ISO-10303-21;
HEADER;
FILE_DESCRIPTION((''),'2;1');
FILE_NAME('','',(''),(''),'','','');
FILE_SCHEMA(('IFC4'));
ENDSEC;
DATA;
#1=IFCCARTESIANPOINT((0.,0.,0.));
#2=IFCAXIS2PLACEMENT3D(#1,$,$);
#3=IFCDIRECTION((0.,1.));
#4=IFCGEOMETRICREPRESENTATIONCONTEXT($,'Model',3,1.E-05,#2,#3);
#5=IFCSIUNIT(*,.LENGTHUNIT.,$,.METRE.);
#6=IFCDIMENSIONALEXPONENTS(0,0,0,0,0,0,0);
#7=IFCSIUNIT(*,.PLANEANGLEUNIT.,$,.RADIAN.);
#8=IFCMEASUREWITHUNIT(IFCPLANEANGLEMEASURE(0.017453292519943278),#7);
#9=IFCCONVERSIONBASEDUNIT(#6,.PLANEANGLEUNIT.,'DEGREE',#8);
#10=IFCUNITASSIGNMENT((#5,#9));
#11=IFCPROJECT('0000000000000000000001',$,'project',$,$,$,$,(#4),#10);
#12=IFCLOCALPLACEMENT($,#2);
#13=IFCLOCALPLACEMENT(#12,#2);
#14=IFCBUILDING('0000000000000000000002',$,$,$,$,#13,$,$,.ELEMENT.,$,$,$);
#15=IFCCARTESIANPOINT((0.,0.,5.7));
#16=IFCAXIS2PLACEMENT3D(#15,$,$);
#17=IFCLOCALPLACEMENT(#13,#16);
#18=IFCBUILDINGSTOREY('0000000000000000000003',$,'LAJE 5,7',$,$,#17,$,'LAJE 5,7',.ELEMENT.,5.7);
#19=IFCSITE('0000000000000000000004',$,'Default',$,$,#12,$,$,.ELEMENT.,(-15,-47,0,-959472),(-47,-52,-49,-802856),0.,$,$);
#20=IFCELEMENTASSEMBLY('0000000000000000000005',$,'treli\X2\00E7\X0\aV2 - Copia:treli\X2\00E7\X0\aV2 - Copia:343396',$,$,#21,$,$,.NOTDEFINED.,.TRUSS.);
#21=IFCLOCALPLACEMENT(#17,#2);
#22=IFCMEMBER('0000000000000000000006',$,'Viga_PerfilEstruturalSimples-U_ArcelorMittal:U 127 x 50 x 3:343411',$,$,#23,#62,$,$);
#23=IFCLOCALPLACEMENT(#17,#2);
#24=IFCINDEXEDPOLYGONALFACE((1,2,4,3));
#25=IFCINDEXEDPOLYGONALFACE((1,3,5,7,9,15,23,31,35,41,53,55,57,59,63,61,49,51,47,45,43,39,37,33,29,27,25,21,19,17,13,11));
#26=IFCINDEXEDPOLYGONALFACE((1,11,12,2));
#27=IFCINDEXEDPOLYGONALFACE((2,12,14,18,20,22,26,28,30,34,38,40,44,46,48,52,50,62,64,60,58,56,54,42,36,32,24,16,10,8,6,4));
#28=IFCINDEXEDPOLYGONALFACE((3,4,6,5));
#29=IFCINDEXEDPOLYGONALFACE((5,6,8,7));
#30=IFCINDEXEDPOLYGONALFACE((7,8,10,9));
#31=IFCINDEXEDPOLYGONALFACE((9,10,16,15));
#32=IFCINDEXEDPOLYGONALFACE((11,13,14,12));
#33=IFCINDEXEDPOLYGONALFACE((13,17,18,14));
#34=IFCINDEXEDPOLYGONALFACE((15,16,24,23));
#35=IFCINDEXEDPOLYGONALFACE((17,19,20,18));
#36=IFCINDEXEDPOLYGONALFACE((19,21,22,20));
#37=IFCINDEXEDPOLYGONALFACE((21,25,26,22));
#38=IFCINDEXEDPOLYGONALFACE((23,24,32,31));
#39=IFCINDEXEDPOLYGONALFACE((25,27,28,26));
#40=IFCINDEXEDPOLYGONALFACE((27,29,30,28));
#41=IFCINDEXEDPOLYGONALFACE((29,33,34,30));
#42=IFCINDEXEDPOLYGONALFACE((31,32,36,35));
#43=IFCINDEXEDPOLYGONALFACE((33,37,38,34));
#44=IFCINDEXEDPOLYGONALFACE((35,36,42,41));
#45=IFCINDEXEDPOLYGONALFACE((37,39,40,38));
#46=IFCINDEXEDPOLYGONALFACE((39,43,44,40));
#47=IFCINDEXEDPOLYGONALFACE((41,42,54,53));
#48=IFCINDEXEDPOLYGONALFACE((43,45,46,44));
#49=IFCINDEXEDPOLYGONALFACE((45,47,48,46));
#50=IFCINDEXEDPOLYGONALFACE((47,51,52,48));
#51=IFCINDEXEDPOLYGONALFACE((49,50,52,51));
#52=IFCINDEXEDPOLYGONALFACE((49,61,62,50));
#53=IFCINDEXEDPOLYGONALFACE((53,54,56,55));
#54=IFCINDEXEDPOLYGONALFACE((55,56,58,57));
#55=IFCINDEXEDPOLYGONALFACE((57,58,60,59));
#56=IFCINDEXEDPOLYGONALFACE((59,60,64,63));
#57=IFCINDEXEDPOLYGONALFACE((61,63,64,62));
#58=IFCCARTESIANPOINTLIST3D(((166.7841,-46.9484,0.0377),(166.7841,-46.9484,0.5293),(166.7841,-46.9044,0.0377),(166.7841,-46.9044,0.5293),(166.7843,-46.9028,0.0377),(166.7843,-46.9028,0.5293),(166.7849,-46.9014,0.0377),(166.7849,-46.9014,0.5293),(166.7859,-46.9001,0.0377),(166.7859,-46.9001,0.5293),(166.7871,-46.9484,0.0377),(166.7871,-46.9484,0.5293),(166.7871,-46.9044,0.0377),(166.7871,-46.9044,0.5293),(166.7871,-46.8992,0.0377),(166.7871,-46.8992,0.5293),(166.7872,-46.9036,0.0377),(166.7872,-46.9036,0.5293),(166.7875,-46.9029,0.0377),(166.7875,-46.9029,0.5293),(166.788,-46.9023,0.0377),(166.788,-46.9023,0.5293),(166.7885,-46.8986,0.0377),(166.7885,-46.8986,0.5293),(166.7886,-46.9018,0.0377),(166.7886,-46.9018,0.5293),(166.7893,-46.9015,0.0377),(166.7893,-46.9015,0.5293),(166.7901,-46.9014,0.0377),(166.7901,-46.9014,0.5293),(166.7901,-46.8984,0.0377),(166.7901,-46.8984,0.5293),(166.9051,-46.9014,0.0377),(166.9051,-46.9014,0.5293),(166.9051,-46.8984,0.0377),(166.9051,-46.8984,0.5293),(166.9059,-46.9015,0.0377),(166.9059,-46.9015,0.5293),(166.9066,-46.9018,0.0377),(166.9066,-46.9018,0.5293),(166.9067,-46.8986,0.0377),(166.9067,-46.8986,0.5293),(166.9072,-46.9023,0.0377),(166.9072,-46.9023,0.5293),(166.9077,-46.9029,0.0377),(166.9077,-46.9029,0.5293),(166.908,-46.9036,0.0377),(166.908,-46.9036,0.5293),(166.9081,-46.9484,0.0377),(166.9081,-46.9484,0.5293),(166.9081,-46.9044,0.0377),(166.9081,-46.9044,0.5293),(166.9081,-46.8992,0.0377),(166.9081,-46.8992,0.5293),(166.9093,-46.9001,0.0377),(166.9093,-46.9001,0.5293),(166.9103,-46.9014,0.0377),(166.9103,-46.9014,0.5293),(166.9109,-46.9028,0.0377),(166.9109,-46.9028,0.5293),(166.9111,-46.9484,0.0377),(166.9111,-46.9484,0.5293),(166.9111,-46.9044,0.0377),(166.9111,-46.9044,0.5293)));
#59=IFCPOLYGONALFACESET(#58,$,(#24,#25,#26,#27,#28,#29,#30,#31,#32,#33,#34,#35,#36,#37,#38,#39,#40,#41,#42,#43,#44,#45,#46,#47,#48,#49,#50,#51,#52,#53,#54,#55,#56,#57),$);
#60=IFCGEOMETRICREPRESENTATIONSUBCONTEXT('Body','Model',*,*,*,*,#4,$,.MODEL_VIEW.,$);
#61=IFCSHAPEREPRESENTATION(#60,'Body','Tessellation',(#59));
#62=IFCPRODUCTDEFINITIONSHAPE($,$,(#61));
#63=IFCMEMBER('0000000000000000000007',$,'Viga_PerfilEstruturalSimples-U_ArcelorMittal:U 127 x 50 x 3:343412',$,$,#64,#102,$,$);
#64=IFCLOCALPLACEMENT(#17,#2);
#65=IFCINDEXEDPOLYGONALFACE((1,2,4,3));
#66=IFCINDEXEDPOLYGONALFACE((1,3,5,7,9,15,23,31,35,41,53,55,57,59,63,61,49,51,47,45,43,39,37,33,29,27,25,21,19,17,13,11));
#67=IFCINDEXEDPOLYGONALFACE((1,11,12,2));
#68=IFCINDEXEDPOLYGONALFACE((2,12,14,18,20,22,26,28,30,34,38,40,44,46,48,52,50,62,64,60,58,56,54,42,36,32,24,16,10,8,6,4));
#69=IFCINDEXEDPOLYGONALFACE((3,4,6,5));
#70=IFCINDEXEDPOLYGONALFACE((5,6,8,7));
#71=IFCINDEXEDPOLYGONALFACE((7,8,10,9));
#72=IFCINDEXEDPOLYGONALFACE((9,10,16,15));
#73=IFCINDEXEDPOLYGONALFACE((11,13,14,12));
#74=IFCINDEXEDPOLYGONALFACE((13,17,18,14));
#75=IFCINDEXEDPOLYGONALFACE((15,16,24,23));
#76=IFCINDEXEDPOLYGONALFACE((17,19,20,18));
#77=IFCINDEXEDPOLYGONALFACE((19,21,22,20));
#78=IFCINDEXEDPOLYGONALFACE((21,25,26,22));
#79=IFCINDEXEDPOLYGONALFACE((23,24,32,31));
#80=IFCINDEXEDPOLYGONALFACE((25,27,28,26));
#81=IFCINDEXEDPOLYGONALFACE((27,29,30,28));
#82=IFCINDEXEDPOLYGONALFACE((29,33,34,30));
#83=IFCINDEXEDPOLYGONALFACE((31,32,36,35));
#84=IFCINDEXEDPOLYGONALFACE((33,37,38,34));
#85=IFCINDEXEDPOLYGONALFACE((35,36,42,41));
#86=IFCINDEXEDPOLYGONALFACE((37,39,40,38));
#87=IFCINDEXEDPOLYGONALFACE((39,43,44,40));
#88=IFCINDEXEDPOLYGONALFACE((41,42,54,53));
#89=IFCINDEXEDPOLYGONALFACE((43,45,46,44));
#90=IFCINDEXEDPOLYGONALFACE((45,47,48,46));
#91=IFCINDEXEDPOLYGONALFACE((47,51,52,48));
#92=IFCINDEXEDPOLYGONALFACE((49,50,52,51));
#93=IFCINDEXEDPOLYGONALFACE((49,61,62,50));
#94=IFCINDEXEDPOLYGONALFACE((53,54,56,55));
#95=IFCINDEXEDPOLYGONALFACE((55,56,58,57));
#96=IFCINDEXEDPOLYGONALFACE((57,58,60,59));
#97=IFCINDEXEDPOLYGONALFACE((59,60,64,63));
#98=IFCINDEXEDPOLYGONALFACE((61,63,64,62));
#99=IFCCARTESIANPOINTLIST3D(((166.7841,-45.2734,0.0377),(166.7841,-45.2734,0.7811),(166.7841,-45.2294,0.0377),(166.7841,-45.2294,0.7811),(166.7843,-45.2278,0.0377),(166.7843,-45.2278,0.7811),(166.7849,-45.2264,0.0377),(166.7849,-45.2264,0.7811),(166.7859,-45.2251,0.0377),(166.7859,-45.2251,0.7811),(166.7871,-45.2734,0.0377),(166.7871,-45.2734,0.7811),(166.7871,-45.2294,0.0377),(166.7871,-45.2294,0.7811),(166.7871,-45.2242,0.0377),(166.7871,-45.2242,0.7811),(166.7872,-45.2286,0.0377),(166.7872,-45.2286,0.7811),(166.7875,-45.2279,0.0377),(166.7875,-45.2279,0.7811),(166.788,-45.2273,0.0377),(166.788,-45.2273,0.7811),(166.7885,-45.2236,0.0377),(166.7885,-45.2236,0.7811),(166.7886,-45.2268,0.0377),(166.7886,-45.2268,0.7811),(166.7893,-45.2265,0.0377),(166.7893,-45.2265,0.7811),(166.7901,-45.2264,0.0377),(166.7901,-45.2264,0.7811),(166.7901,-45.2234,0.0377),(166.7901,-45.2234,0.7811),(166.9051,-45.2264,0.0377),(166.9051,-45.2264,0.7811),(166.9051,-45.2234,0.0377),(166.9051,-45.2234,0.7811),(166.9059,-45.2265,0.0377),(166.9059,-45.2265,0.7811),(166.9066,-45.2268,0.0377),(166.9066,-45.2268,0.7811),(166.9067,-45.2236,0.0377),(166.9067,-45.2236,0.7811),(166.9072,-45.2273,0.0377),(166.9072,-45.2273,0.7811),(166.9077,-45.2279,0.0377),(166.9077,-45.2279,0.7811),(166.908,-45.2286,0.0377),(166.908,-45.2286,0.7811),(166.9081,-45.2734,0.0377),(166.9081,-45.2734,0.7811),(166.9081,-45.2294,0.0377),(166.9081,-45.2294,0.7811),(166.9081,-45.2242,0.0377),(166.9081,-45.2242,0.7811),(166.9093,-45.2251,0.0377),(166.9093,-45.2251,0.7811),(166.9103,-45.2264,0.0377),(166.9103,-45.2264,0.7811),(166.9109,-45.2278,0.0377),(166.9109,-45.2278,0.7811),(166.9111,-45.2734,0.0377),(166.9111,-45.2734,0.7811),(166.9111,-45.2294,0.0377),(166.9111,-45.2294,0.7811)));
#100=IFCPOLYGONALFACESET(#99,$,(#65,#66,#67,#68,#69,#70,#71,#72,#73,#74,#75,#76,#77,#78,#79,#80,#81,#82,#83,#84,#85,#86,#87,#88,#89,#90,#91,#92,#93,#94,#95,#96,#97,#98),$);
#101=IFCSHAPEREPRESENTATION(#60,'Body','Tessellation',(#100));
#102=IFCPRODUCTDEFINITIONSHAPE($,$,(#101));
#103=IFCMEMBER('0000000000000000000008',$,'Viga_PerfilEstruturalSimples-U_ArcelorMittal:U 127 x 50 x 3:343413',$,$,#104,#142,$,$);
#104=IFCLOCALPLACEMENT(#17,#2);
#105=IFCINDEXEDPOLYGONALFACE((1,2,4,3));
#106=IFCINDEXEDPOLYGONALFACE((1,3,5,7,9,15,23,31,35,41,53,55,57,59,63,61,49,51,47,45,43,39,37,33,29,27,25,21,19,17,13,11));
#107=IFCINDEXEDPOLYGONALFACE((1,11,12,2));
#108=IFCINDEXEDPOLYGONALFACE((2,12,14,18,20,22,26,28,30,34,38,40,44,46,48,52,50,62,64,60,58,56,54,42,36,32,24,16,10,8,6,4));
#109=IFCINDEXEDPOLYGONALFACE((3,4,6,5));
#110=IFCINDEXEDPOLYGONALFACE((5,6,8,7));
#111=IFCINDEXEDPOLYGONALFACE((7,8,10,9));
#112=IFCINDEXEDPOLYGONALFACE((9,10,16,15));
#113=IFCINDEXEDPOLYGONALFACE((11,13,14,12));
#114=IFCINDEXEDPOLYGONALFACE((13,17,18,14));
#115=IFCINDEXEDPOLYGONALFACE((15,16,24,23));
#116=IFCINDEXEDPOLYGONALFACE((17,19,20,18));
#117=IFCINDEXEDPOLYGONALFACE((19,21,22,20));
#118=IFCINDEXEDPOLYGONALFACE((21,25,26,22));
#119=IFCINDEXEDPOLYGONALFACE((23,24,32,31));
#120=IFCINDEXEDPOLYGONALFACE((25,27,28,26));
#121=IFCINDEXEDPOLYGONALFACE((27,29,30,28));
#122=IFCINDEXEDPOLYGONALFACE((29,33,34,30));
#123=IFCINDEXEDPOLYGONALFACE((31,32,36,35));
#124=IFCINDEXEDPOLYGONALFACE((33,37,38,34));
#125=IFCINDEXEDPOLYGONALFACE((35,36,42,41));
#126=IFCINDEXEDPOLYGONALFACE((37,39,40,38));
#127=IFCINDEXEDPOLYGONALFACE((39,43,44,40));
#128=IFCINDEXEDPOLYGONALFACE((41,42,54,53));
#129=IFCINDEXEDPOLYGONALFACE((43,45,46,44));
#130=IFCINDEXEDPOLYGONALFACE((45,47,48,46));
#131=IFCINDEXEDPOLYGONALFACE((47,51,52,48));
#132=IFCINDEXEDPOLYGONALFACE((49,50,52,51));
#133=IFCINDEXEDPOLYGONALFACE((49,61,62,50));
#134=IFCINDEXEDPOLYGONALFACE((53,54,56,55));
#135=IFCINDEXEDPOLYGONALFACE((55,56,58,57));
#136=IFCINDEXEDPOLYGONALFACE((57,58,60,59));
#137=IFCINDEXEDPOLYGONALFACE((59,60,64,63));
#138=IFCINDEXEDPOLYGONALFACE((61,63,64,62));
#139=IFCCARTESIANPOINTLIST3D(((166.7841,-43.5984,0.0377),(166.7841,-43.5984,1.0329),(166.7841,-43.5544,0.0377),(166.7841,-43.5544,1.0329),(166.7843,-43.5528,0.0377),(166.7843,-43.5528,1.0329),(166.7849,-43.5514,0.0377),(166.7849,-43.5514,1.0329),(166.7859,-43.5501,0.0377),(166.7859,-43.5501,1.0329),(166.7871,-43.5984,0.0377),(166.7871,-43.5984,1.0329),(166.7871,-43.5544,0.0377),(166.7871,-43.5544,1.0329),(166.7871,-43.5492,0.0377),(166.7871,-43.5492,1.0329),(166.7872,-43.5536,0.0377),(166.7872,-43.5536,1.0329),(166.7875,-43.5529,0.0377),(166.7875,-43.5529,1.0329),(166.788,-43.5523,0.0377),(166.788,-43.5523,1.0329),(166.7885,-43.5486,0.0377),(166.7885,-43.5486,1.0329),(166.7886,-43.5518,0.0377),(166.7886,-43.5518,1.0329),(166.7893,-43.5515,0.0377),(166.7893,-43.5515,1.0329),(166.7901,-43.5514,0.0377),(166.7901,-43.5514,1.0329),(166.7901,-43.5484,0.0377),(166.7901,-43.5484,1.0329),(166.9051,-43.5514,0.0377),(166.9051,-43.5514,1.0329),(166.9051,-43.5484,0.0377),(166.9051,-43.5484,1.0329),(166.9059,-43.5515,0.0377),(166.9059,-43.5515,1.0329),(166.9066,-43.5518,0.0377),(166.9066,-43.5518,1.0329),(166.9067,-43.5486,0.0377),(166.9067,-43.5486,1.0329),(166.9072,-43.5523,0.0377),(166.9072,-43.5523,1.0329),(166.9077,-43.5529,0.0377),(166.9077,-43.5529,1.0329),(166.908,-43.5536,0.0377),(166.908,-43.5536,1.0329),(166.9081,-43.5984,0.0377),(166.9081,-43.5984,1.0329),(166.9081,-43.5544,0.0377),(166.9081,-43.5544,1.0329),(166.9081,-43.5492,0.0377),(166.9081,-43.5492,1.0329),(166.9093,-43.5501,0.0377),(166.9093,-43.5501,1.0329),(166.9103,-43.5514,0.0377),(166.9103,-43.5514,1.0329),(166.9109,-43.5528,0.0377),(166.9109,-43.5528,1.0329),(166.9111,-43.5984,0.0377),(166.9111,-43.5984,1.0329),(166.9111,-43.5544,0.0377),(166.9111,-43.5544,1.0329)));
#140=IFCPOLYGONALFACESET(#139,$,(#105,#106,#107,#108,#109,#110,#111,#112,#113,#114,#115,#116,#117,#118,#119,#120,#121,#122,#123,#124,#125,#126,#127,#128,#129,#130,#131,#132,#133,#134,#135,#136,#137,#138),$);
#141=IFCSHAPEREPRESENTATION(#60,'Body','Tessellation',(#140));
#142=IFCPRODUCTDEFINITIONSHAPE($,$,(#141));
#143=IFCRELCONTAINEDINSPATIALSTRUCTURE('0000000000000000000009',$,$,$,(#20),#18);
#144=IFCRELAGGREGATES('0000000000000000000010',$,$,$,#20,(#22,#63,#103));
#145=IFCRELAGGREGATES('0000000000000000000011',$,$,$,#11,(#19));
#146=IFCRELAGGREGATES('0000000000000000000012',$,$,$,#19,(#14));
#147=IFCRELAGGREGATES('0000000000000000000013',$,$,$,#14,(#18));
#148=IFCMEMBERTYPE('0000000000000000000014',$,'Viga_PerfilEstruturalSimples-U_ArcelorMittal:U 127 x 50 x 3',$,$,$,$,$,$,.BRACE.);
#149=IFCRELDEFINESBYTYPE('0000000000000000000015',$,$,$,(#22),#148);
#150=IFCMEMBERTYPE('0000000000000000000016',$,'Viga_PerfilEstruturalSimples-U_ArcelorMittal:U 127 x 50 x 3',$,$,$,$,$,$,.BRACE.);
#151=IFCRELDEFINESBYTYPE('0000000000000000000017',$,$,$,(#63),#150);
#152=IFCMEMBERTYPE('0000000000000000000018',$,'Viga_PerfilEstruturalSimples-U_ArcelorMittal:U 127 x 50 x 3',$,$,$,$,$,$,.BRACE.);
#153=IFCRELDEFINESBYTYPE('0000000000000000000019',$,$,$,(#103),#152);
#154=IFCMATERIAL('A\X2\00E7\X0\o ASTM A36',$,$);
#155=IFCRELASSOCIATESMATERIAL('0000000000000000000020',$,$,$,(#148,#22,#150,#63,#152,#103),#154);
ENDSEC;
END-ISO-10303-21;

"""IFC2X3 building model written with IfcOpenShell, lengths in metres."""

from ifc_helpers import new_model, entity, si_unit, converted_unit, direction, frame, frame_2d, origin, place, context, subcontext, project, spatial, polyline, circle_curve, parameter, trimmed, segment, composite_curve, outline, extrude, source, transform, mapped, material, type_object, type_shapes, element, aggregate, save


model = new_model("IFC2X3")

# Units and contexts
model_context = context("Model", 3, precision=1e-05, world=origin(), true_north=direction((0.0, 1.0)))
body_context = subcontext(model_context, "Body", "Model", "MODEL_VIEW")
ifc_project = project(units=[si_unit("LENGTHUNIT", "METRE"), converted_unit("PLANEANGLEUNIT", "DEGREE", entity("IfcPlaneAngleMeasure", 0.017453292519943278), si_unit("PLANEANGLEUNIT", "RADIAN"), dimensions=[0, 0, 0, 0, 0, 0, 0])], contexts=[model_context])

# Site, building, storey
site_placement = place(None, origin())
site = spatial("IfcSite", under=ifc_project, at=site_placement, Name="Default", CompositionType="ELEMENT", RefLatitude=(-15, -47, 0, -959472), RefLongitude=(-47, -52, -49, -802856), RefElevation=0.0)
building_placement = place(site_placement, origin())
building = spatial("IfcBuilding", under=site, at=building_placement, CompositionType="ELEMENT")
storey_placement = place(building_placement, frame((0.0, 0.0, 5.7)))
storey = spatial("IfcBuildingStorey", under=building, at=storey_placement, Name="LAJE 5,7", LongName="LAJE 5,7", CompositionType="ELEMENT", Elevation=5.7)

# Element assembly
assembly_1_placement = place(storey_placement, origin())
assembly_1 = element("IfcElementAssembly", 1, at=assembly_1_placement, inside=storey, Name="treliçaV2 - Copia:treliçaV2 - Copia:343396", AssemblyPlace="NOTDEFINED", PredefinedType="TRUSS")
ifc_material = material(Name="Aço ASTM A36")

# Members
member_type_1 = type_object("IfcMemberType", Name="Viga_PerfilEstruturalSimples-U_ArcelorMittal:U 127 x 50 x 3", PredefinedType="BRACE", material=ifc_material)
shared_shape_1 = source(origin(), body_context, "Body", "SweptSolid", [
    extrude(outline(composite_curve([segment(polyline([(-0.0575, -0.0192), (0.0575, -0.0192)]), True, "CONTINUOUS"), segment(trimmed(circle_curve(frame_2d((0.0575, -0.0132), x_axis=(0.0, 1.0)), 0.006), [parameter(180.0)], [parameter(270.0)], True, "PARAMETER"), True, "CONTINUOUS"), segment(polyline([(0.0635, -0.0132), (0.0635, 0.0308)]), True, "CONTINUOUS"), segment(polyline([(0.0635, 0.0308), (0.0605, 0.0308)]), True, "CONTINUOUS"), segment(polyline([(0.0605, 0.0308), (0.0605, -0.0132)]), True, "CONTINUOUS"), segment(trimmed(circle_curve(frame_2d((0.0575, -0.0132), x_axis=(0.0, 1.0)), 0.003), [parameter(180.0)], [parameter(270.0)], True, "PARAMETER"), False, "CONTINUOUS"), segment(polyline([(0.0575, -0.0162), (-0.0575, -0.0162)]), True, "CONTINUOUS"), segment(trimmed(circle_curve(frame_2d((-0.0575, -0.0132), x_axis=(0.0, 1.0)), 0.003), [parameter(90.0)], [parameter(180.0)], True, "PARAMETER"), False, "CONTINUOUS"), segment(polyline([(-0.0605, -0.0132), (-0.0605, 0.0308)]), True, "CONTINUOUS"), segment(polyline([(-0.0605, 0.0308), (-0.0635, 0.0308)]), True, "CONTINUOUS"), segment(polyline([(-0.0635, 0.0308), (-0.0635, -0.0132)]), True, "CONTINUOUS"), segment(trimmed(circle_curve(frame_2d((-0.0575, -0.0132), x_axis=(0.0, 1.0)), 0.006), [parameter(90.0)], [parameter(180.0)], True, "PARAMETER"), True, "CONTINUOUS")], self_intersect=False)), frame((-0.2478, -0.0058, 0.0), z_axis=(1.0, 0.0, 0.0), x_axis=(0.0, 0.0, -1.0)), (0.0, 0.0, 1.0), 0.4916),
])
type_shapes(member_type_1, [shared_shape_1])
member_1_placement = place(assembly_1_placement, frame((166.8476, -46.9234, 0.2855), z_axis=(1.0, 0.0, 0.0), x_axis=(0.0, 0.0, 1.0)))
member_1 = element("IfcMember", 2, at=member_1_placement, type_object=member_type_1, material=ifc_material, Name="Viga_PerfilEstruturalSimples-U_ArcelorMittal:U 127 x 50 x 3:343411", context=body_context, shape_type="MappedRepresentation", body=[
    mapped(shared_shape_1, transform((0.0, 0.0, 0.0), scale=1.0)),
])
member_type_2 = type_object("IfcMemberType", Name="Viga_PerfilEstruturalSimples-U_ArcelorMittal:U 127 x 50 x 3", PredefinedType="BRACE", material=ifc_material)
shared_shape_2 = source(origin(), body_context, "Body", "SweptSolid", [
    extrude(outline(composite_curve([segment(polyline([(-0.0575, -0.0192), (0.0575, -0.0192)]), True, "CONTINUOUS"), segment(trimmed(circle_curve(frame_2d((0.0575, -0.0132), x_axis=(0.0, 1.0)), 0.006), [parameter(180.0)], [parameter(270.0)], True, "PARAMETER"), True, "CONTINUOUS"), segment(polyline([(0.0635, -0.0132), (0.0635, 0.0308)]), True, "CONTINUOUS"), segment(polyline([(0.0635, 0.0308), (0.0605, 0.0308)]), True, "CONTINUOUS"), segment(polyline([(0.0605, 0.0308), (0.0605, -0.0132)]), True, "CONTINUOUS"), segment(trimmed(circle_curve(frame_2d((0.0575, -0.0132), x_axis=(0.0, 1.0)), 0.003), [parameter(180.0)], [parameter(270.0)], True, "PARAMETER"), False, "CONTINUOUS"), segment(polyline([(0.0575, -0.0162), (-0.0575, -0.0162)]), True, "CONTINUOUS"), segment(trimmed(circle_curve(frame_2d((-0.0575, -0.0132), x_axis=(0.0, 1.0)), 0.003), [parameter(90.0)], [parameter(180.0)], True, "PARAMETER"), False, "CONTINUOUS"), segment(polyline([(-0.0605, -0.0132), (-0.0605, 0.0308)]), True, "CONTINUOUS"), segment(polyline([(-0.0605, 0.0308), (-0.0635, 0.0308)]), True, "CONTINUOUS"), segment(polyline([(-0.0635, 0.0308), (-0.0635, -0.0132)]), True, "CONTINUOUS"), segment(trimmed(circle_curve(frame_2d((-0.0575, -0.0132), x_axis=(0.0, 1.0)), 0.006), [parameter(90.0)], [parameter(180.0)], True, "PARAMETER"), True, "CONTINUOUS")], self_intersect=False)), frame((-0.3737, -0.0058, 0.0), z_axis=(1.0, 0.0, 0.0), x_axis=(0.0, 0.0, -1.0)), (0.0, 0.0, 1.0), 0.7434),
])
type_shapes(member_type_2, [shared_shape_2])
member_2_placement = place(assembly_1_placement, frame((166.8476, -45.2484, 0.4114), z_axis=(1.0, 0.0, 0.0), x_axis=(0.0, 0.0, 1.0)))
member_2 = element("IfcMember", 3, at=member_2_placement, type_object=member_type_2, material=ifc_material, Name="Viga_PerfilEstruturalSimples-U_ArcelorMittal:U 127 x 50 x 3:343412", context=body_context, shape_type="MappedRepresentation", body=[
    mapped(shared_shape_2, transform((0.0, 0.0, 0.0), scale=1.0)),
])
member_type_3 = type_object("IfcMemberType", Name="Viga_PerfilEstruturalSimples-U_ArcelorMittal:U 127 x 50 x 3", PredefinedType="BRACE", material=ifc_material)
shared_shape_3 = source(origin(), body_context, "Body", "SweptSolid", [
    extrude(outline(composite_curve([segment(polyline([(-0.0575, -0.0192), (0.0575, -0.0192)]), True, "CONTINUOUS"), segment(trimmed(circle_curve(frame_2d((0.0575, -0.0132), x_axis=(0.0, 1.0)), 0.006), [parameter(180.0)], [parameter(270.0)], True, "PARAMETER"), True, "CONTINUOUS"), segment(polyline([(0.0635, -0.0132), (0.0635, 0.0308)]), True, "CONTINUOUS"), segment(polyline([(0.0635, 0.0308), (0.0605, 0.0308)]), True, "CONTINUOUS"), segment(polyline([(0.0605, 0.0308), (0.0605, -0.0132)]), True, "CONTINUOUS"), segment(trimmed(circle_curve(frame_2d((0.0575, -0.0132), x_axis=(0.0, 1.0)), 0.003), [parameter(180.0)], [parameter(270.0)], True, "PARAMETER"), False, "CONTINUOUS"), segment(polyline([(0.0575, -0.0162), (-0.0575, -0.0162)]), True, "CONTINUOUS"), segment(trimmed(circle_curve(frame_2d((-0.0575, -0.0132), x_axis=(0.0, 1.0)), 0.003), [parameter(90.0)], [parameter(180.0)], True, "PARAMETER"), False, "CONTINUOUS"), segment(polyline([(-0.0605, -0.0132), (-0.0605, 0.0308)]), True, "CONTINUOUS"), segment(polyline([(-0.0605, 0.0308), (-0.0635, 0.0308)]), True, "CONTINUOUS"), segment(polyline([(-0.0635, 0.0308), (-0.0635, -0.0132)]), True, "CONTINUOUS"), segment(trimmed(circle_curve(frame_2d((-0.0575, -0.0132), x_axis=(0.0, 1.0)), 0.006), [parameter(90.0)], [parameter(180.0)], True, "PARAMETER"), True, "CONTINUOUS")], self_intersect=False)), frame((-0.4996, -0.0058, 0.0), z_axis=(1.0, 0.0, 0.0), x_axis=(0.0, 0.0, -1.0)), (0.0, 0.0, 1.0), 0.9952),
])
type_shapes(member_type_3, [shared_shape_3])
member_3_placement = place(assembly_1_placement, frame((166.8476, -43.5734, 0.5373), z_axis=(1.0, 0.0, 0.0), x_axis=(0.0, 0.0, 1.0)))
member_3 = element("IfcMember", 4, at=member_3_placement, type_object=member_type_3, material=ifc_material, Name="Viga_PerfilEstruturalSimples-U_ArcelorMittal:U 127 x 50 x 3:343413", context=body_context, shape_type="MappedRepresentation", body=[
    mapped(shared_shape_3, transform((0.0, 0.0, 0.0), scale=1.0)),
])
aggregate(assembly_1, [member_1, member_2, member_3])

save(model, "model.ifc")
